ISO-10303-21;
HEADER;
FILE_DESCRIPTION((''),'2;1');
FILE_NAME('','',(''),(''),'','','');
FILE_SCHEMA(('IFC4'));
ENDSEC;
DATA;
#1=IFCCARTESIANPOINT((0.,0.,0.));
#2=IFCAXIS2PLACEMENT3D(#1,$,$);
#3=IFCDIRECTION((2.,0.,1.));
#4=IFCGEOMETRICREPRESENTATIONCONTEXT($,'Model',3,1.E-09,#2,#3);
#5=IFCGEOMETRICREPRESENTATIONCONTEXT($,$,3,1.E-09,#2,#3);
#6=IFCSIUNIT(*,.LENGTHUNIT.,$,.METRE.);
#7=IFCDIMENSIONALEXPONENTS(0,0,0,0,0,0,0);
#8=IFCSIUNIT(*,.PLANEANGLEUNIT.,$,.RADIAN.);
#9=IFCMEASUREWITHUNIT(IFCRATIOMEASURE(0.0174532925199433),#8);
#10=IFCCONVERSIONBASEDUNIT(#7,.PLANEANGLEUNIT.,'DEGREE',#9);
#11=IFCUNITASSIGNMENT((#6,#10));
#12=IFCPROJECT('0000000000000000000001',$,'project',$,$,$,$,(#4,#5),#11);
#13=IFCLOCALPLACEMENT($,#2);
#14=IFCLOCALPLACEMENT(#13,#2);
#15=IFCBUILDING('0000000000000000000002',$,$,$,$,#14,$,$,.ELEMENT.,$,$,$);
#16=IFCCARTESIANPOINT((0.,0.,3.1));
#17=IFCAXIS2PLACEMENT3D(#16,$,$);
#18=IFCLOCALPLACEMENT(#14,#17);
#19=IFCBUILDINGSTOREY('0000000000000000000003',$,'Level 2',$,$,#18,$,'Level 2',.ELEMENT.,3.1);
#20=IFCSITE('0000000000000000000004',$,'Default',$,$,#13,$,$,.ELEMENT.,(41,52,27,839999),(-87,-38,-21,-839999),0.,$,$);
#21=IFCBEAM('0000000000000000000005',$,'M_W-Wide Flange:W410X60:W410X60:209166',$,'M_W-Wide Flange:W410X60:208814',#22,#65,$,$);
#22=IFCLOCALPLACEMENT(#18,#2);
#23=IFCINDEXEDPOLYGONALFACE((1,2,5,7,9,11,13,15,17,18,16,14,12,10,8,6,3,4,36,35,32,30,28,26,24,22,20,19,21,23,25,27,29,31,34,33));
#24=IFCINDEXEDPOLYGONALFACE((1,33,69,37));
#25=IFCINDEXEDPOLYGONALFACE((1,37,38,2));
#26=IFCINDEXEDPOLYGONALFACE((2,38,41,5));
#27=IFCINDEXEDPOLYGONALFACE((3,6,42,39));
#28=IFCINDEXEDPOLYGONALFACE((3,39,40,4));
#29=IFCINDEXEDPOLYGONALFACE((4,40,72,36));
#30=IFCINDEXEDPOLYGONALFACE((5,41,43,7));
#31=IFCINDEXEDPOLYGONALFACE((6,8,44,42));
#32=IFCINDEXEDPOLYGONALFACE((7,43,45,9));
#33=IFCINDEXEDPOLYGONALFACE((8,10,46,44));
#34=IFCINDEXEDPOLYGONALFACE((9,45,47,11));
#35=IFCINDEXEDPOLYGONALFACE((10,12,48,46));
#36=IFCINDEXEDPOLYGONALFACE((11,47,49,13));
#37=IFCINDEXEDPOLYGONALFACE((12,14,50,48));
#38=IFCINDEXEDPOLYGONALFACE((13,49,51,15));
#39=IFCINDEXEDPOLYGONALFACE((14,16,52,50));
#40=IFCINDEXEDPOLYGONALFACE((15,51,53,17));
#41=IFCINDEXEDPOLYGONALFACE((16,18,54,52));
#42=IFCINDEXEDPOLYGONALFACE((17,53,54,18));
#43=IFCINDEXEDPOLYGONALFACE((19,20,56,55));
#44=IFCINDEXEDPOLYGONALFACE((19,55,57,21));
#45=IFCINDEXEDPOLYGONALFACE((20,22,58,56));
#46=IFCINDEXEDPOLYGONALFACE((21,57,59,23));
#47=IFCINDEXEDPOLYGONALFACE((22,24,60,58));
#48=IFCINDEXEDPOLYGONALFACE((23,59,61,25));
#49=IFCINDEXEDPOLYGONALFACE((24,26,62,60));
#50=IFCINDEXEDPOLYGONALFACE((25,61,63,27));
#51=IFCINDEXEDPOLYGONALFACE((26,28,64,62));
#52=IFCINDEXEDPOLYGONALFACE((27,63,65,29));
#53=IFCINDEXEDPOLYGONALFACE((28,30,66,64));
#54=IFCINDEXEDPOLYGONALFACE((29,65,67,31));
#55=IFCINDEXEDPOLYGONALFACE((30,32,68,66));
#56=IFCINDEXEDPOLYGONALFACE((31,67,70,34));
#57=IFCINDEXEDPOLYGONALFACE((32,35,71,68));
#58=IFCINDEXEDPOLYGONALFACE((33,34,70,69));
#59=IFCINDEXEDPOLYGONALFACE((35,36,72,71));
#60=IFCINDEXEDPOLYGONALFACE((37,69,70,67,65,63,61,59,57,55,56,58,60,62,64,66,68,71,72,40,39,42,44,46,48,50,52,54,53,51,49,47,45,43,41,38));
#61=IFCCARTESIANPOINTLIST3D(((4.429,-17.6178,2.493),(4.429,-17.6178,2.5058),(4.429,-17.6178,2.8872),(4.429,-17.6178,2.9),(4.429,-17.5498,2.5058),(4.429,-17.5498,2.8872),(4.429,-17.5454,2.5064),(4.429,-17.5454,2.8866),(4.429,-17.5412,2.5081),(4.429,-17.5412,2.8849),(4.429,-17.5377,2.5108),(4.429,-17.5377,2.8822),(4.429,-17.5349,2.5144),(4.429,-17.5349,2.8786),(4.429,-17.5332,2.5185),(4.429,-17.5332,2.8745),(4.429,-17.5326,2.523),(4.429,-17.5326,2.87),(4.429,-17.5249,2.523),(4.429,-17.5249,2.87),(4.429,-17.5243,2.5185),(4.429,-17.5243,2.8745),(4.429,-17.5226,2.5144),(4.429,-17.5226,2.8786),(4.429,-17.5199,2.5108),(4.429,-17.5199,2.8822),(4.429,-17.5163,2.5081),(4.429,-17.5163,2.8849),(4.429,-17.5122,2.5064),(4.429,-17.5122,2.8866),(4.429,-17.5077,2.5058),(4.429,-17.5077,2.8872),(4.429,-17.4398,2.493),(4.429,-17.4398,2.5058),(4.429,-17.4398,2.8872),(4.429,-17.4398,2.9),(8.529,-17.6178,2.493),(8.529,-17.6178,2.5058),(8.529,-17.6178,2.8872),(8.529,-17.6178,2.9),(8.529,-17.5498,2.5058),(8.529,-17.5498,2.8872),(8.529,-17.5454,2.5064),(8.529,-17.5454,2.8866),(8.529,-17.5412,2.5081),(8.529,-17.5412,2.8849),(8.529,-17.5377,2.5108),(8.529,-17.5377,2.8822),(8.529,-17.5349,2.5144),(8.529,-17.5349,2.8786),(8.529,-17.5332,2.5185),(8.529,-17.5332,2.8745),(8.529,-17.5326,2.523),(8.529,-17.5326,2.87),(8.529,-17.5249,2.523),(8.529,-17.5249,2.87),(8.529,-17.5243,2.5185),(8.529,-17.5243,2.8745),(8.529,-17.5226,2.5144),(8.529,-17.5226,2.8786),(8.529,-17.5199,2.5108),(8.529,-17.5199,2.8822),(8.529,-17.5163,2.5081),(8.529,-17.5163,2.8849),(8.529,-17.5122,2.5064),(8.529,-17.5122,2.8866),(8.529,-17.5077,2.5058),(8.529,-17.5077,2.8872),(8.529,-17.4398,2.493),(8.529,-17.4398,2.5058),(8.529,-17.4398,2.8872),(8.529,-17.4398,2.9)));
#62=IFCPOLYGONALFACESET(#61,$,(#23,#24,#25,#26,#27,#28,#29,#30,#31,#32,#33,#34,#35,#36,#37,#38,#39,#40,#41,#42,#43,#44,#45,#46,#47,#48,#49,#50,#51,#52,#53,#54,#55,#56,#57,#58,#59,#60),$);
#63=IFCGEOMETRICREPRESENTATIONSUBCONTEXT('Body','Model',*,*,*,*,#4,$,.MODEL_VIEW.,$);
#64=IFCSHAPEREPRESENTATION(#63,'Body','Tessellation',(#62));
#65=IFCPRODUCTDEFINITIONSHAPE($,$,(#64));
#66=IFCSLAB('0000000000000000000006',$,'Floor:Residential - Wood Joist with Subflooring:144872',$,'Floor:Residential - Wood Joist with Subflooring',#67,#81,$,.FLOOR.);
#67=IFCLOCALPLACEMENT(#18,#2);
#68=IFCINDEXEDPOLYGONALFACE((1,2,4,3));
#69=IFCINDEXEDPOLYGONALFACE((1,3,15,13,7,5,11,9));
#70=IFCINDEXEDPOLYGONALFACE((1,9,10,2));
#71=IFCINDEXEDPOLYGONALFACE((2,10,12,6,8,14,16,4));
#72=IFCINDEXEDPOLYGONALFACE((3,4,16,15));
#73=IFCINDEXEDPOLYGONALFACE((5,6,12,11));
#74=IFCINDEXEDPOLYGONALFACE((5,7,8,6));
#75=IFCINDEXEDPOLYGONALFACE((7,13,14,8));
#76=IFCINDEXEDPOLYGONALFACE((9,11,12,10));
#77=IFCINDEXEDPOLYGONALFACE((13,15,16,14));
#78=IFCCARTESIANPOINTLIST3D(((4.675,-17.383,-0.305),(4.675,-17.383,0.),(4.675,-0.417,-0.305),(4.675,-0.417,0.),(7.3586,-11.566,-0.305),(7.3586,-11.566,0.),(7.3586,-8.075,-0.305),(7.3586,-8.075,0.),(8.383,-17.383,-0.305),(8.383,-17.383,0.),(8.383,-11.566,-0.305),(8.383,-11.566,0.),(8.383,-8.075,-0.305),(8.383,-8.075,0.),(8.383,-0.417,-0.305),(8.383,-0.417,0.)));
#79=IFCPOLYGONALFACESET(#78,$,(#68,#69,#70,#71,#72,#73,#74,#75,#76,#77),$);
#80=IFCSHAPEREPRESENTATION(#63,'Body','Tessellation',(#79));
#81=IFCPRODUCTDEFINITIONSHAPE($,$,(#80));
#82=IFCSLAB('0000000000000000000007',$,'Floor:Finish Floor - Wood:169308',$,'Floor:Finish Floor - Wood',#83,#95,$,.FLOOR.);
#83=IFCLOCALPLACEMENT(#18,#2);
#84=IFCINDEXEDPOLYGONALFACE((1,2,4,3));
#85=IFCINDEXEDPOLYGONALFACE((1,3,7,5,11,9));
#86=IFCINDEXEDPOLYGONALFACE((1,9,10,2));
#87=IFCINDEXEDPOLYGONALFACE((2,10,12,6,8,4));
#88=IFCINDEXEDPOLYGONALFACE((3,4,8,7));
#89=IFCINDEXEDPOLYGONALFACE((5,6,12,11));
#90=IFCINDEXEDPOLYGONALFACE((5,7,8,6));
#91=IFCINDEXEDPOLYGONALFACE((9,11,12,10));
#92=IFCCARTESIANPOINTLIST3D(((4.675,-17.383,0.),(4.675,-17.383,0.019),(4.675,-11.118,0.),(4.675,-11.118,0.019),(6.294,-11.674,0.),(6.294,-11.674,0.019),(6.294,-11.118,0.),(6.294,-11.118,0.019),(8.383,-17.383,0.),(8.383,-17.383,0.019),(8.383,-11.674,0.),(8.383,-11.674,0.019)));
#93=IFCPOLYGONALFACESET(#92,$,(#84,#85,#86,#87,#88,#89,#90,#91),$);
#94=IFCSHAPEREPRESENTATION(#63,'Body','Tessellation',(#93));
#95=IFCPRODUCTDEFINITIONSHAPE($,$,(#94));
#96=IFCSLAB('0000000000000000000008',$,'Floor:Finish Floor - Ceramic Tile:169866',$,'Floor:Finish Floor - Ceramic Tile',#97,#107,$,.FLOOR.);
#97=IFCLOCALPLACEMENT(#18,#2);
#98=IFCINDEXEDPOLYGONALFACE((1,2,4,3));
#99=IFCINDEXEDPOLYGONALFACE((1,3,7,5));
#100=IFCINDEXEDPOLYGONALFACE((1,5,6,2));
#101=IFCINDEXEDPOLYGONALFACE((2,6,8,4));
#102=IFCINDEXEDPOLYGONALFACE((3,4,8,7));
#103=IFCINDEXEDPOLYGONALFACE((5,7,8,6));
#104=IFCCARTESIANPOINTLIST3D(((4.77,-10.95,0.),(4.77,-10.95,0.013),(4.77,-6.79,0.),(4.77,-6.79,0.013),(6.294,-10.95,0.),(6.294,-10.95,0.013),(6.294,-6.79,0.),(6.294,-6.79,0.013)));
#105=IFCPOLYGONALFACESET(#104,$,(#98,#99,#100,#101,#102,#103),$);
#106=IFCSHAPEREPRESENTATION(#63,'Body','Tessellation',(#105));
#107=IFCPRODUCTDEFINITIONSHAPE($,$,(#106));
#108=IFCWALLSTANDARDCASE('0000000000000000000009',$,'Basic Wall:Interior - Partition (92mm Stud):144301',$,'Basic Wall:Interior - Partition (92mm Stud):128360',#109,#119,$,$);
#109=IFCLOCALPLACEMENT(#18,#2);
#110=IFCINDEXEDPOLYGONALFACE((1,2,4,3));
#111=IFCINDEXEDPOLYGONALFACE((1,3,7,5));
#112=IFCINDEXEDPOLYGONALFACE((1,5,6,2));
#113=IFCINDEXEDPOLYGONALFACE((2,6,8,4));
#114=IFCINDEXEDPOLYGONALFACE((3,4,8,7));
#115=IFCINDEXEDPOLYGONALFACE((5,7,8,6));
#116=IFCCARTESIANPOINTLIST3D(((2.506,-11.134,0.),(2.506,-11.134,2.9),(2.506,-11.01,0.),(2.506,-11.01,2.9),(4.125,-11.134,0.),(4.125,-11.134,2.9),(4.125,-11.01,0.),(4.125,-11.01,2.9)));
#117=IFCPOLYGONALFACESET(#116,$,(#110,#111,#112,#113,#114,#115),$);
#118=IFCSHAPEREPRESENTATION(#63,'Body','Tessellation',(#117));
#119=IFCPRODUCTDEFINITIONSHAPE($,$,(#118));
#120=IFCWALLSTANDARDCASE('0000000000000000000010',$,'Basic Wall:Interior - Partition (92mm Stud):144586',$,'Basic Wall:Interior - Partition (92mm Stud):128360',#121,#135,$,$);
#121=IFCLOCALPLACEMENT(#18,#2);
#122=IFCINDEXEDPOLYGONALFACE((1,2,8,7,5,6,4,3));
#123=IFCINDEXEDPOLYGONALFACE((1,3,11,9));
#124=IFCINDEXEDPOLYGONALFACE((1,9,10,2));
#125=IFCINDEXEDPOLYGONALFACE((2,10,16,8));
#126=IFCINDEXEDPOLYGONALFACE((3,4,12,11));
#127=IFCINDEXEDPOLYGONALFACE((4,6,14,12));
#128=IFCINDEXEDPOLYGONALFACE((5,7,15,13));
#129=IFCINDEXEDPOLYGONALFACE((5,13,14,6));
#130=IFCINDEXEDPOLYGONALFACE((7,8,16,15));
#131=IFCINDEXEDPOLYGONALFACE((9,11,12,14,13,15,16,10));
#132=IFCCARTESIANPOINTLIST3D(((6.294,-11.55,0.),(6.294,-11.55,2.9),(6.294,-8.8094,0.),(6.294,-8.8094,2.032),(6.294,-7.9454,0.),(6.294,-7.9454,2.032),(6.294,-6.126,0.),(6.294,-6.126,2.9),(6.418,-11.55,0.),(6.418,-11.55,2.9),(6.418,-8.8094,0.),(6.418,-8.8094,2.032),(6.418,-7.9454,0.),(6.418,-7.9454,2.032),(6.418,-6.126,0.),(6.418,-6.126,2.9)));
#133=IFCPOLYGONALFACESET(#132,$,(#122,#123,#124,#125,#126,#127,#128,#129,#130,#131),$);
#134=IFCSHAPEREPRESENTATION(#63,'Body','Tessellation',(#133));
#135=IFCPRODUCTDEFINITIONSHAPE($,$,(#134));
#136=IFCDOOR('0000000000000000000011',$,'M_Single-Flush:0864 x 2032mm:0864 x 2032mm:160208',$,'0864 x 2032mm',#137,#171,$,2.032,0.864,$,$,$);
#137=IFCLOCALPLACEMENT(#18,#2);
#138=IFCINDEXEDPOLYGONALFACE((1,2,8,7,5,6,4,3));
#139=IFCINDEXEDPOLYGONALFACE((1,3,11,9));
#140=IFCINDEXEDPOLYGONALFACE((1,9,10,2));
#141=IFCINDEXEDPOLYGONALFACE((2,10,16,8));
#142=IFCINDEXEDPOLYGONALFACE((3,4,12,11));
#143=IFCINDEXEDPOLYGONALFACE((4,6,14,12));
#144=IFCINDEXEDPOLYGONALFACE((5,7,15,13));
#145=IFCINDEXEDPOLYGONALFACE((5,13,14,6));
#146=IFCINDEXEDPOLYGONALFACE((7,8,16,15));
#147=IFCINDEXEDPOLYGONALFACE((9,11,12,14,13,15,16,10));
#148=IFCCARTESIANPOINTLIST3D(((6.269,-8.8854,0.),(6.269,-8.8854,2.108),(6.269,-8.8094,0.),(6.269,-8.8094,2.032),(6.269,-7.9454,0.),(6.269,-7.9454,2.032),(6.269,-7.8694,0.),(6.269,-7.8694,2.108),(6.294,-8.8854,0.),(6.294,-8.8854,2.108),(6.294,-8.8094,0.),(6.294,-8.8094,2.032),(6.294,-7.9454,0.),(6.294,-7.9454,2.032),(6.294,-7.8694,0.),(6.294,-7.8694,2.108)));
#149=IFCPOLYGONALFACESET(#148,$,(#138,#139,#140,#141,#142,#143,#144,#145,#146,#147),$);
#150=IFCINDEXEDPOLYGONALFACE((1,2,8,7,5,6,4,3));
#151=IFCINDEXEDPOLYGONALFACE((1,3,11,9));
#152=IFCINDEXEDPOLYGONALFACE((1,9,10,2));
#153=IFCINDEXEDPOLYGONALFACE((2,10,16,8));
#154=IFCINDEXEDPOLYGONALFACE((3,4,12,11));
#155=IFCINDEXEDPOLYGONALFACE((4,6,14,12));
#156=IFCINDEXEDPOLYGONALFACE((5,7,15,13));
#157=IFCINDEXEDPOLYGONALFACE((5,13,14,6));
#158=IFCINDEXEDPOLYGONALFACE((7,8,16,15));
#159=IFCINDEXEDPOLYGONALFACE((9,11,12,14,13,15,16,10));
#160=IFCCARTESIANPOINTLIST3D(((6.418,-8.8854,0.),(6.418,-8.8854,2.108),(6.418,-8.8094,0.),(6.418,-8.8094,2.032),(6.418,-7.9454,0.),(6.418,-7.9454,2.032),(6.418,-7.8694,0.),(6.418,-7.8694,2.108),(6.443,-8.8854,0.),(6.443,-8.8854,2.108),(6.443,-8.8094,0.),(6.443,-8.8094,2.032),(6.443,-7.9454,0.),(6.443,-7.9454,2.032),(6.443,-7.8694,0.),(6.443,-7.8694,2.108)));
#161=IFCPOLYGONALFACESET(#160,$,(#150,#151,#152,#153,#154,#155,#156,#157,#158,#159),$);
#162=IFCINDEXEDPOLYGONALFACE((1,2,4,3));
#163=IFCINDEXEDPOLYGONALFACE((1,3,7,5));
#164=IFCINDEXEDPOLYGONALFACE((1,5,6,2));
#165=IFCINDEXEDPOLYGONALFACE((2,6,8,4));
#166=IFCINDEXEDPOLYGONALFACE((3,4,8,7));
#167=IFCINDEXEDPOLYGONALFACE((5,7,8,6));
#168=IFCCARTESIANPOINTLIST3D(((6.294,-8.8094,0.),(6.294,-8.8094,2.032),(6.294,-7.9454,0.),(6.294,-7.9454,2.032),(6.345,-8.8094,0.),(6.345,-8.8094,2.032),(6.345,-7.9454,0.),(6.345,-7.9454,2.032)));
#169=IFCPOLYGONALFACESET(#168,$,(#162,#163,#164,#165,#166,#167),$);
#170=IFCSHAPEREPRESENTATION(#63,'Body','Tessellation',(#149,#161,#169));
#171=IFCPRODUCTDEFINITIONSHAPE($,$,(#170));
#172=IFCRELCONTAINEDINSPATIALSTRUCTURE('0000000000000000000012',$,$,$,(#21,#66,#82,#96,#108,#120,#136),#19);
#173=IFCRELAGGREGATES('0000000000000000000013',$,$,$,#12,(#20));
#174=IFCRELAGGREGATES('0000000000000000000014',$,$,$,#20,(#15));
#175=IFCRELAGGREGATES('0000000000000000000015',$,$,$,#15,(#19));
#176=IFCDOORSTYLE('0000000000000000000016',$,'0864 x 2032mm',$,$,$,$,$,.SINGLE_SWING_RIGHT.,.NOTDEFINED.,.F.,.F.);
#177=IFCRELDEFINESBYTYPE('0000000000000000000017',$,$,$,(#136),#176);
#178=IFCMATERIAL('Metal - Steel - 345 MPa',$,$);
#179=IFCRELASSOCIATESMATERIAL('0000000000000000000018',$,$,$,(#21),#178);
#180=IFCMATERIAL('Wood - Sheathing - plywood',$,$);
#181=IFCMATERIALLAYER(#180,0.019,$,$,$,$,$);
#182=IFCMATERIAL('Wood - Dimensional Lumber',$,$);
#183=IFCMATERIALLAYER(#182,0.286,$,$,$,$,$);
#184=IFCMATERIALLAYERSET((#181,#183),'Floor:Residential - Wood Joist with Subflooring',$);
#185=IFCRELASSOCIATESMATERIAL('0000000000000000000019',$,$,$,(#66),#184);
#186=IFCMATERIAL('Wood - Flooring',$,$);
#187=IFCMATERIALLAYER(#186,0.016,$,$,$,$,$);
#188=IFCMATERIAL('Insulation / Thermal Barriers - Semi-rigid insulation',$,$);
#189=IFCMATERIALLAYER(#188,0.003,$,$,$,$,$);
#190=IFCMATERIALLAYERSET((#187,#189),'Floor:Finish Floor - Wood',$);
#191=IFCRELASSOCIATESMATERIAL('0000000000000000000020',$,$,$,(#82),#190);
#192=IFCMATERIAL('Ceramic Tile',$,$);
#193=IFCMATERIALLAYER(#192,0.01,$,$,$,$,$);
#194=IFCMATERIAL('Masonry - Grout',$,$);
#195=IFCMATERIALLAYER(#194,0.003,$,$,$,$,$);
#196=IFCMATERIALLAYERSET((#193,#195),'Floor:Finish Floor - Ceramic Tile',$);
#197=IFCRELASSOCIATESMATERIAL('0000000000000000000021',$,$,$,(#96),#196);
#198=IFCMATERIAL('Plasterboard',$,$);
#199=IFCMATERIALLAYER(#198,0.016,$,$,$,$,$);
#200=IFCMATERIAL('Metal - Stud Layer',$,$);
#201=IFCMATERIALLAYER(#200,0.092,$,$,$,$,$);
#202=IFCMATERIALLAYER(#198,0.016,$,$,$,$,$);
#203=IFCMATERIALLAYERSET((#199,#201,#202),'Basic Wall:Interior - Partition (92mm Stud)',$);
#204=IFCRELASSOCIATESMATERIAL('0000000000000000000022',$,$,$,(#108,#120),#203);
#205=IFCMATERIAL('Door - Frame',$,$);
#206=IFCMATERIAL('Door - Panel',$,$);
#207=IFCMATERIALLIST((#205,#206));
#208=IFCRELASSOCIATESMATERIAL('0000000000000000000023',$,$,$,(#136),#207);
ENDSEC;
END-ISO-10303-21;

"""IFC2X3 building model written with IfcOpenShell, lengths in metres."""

from ifc_helpers import new_model, entity, si_unit, converted_unit, direction, frame, frame_2d, origin, origin_2d_with_axis, place, context, subcontext, project, spatial, polyline, rectangle, i_section, outline, extrude, source, transform, mapped, material, material_list, layer, layer_set, layer_usage, type_object, type_shapes, element, fill, save


model = new_model("IFC2X3")

# Units and contexts
model_context = context("Model", 3, precision=1e-09, world=origin(), true_north=direction((2.0, 0.0, 1.0)))
context_of_model = context(None, 3, precision=1e-09, world=origin(), true_north=direction((2.0, 0.0, 1.0)))
body_context = subcontext(model_context, "Body", "Model", "MODEL_VIEW")
ifc_project = project(units=[si_unit("LENGTHUNIT", "METRE"), converted_unit("PLANEANGLEUNIT", "DEGREE", entity("IfcRatioMeasure", 0.0174532925199433), si_unit("PLANEANGLEUNIT", "RADIAN"), dimensions=[0, 0, 0, 0, 0, 0, 0])], contexts=[model_context, context_of_model])

# Site, building, storey
site_placement = place(None, origin())
site = spatial("IfcSite", under=ifc_project, at=site_placement, Name="Default", CompositionType="ELEMENT", RefLatitude=(41, 52, 27, 839999), RefLongitude=(-87, -38, -21, -839999), RefElevation=0.0)
building_placement = place(site_placement, origin())
building = spatial("IfcBuilding", under=site, at=building_placement, CompositionType="ELEMENT")
storey_placement = place(building_placement, frame((0.0, 0.0, 3.1)))
storey = spatial("IfcBuildingStorey", under=building, at=storey_placement, Name="Level 2", LongName="Level 2", CompositionType="ELEMENT", Elevation=3.1)

# Beam
ifc_material_1 = material(Name="Metal - Steel - 345 MPa")
beam_placement = place(storey_placement, frame((4.429, -17.5288, 2.9)))
element("IfcBeam", 1, at=beam_placement, inside=storey, material=ifc_material_1, Name="M_W-Wide Flange:W410X60:W410X60:209166", ObjectType="M_W-Wide Flange:W410X60:208814", context=body_context, shape_type="SweptSolid", body=[
    extrude(i_section(OverallWidth=0.178, OverallDepth=0.407, WebThickness=0.0077, FlangeThickness=0.0128, FilletRadius=0.0172, at=frame_2d((0.0, 0.0), x_axis=(1.0, 0.0))), frame((0.0, 0.0, -0.2035), z_axis=(-1.0, 0.0, 0.0), x_axis=(0.0, -1.0, 0.0)), (0.0, 0.0, -1.0), 4.1),
])

# Slabs
ifc_material_2 = material(Name="Wood - Sheathing - plywood")
ifc_layer_1 = layer(ifc_material_2, 0.019)
ifc_material_3 = material(Name="Wood - Dimensional Lumber")
ifc_layer_2 = layer(ifc_material_3, 0.286)
ifc_layer_set_1 = layer_set([ifc_layer_1, ifc_layer_2], Name="Floor:Residential - Wood Joist with Subflooring")
ifc_layer_usage_1 = layer_usage(ifc_layer_set_1, "AXIS3", "POSITIVE", 0.0)
slab_1_placement = place(storey_placement, frame((4.675, -17.383, -0.305)))
element("IfcSlab", 2, at=slab_1_placement, inside=storey, material=ifc_layer_usage_1, Name="Floor:Residential - Wood Joist with Subflooring:144872", ObjectType="Floor:Residential - Wood Joist with Subflooring", PredefinedType="FLOOR", context=body_context, shape_type="SweptSolid", body=[
    extrude(outline(polyline([(-1.854, 8.483), (-1.854, 0.825), (-0.8296, 0.825), (-0.8296, -2.666), (-1.854, -2.666), (-1.854, -8.483), (1.854, -8.483), (1.854, 8.483), (-1.854, 8.483)])), frame((1.854, 8.483, 0.305), z_axis=(0.0, 0.0, -1.0), x_axis=(-1.0, 0.0, 0.0)), (0.0, 0.0, 1.0), 0.305),
])
ifc_material_4 = material(Name="Wood - Flooring")
ifc_layer_3 = layer(ifc_material_4, 0.016)
ifc_material_5 = material(Name="Insulation / Thermal Barriers - Semi-rigid insulation")
ifc_layer_4 = layer(ifc_material_5, 0.003)
ifc_layer_set_2 = layer_set([ifc_layer_3, ifc_layer_4], Name="Floor:Finish Floor - Wood")
ifc_layer_usage_2 = layer_usage(ifc_layer_set_2, "AXIS3", "POSITIVE", 0.0)
slab_2_placement = place(storey_placement, frame((4.675, -17.383, 0.0)))
element("IfcSlab", 3, at=slab_2_placement, inside=storey, material=ifc_layer_usage_2, Name="Floor:Finish Floor - Wood:169308", ObjectType="Floor:Finish Floor - Wood", PredefinedType="FLOOR", context=body_context, shape_type="SweptSolid", body=[
    extrude(outline(polyline([(-1.854, 2.5765), (-1.854, -3.1325), (1.854, -3.1325), (1.854, 3.1325), (0.235, 3.1325), (0.235, 2.5765), (-1.854, 2.5765)])), frame((1.854, 3.1325, 0.019), z_axis=(0.0, 0.0, -1.0), x_axis=(-1.0, 0.0, 0.0)), (0.0, 0.0, 1.0), 0.019),
])
ifc_material_6 = material(Name="Ceramic Tile")
ifc_layer_5 = layer(ifc_material_6, 0.01)
ifc_material_7 = material(Name="Masonry - Grout")
ifc_layer_6 = layer(ifc_material_7, 0.003)
ifc_layer_set_3 = layer_set([ifc_layer_5, ifc_layer_6], Name="Floor:Finish Floor - Ceramic Tile")
ifc_layer_usage_3 = layer_usage(ifc_layer_set_3, "AXIS3", "POSITIVE", 0.0)
slab_3_placement = place(storey_placement, frame((4.77, -10.95, 0.0)))
element("IfcSlab", 4, at=slab_3_placement, inside=storey, material=ifc_layer_usage_3, Name="Floor:Finish Floor - Ceramic Tile:169866", ObjectType="Floor:Finish Floor - Ceramic Tile", PredefinedType="FLOOR", context=body_context, shape_type="SweptSolid", body=[
    extrude(rectangle(XDim=4.16, YDim=1.524, at=frame_2d((0.0, 0.0), x_axis=(0.0, -1.0))), frame((0.762, 2.08, 0.013), z_axis=(0.0, 0.0, -1.0), x_axis=(-1.0, 0.0, 0.0)), (0.0, 0.0, 1.0), 0.013),
])

# Shared definitions
ifc_material_8 = material(Name="Metal - Stud Layer")
ifc_material_9 = material(Name="Plasterboard")

# Wall
ifc_layer_7 = layer(ifc_material_9, 0.016)
ifc_layer_8 = layer(ifc_material_8, 0.092)
ifc_layer_9 = layer(ifc_material_9, 0.016)
ifc_layer_set_4 = layer_set([ifc_layer_7, ifc_layer_8, ifc_layer_9], Name="Basic Wall:Interior - Partition (92mm Stud)")
ifc_layer_usage_4 = layer_usage(ifc_layer_set_4, "AXIS2", "NEGATIVE", 0.062)
wall_1_placement = place(storey_placement, frame((4.125, -11.072, 0.0), z_axis=(0.0, 0.0, 1.0), x_axis=(-1.0, 0.0, 0.0)))
element("IfcWallStandardCase", 5, at=wall_1_placement, inside=storey, material=ifc_layer_usage_4, Name="Basic Wall:Interior - Partition (92mm Stud):144301", ObjectType="Basic Wall:Interior - Partition (92mm Stud):128360", context=body_context, shape_type="SweptSolid", body=[
    extrude(rectangle(XDim=1.619, YDim=0.124, at=frame_2d((0.8095, 0.0), x_axis=(-1.0, 0.0))), origin(), (0.0, 0.0, 1.0), 2.9),
])

# Wall, opening, door
ifc_layer_usage_5 = layer_usage(ifc_layer_set_4, "AXIS2", "NEGATIVE", 0.062)
wall_2_placement = place(storey_placement, frame((6.356, -11.55, 0.0), z_axis=(0.0, 0.0, 1.0), x_axis=(0.0, 1.0, 0.0)))
wall_2 = element("IfcWallStandardCase", 6, at=wall_2_placement, inside=storey, material=ifc_layer_usage_5, Name="Basic Wall:Interior - Partition (92mm Stud):144586", ObjectType="Basic Wall:Interior - Partition (92mm Stud):128360", context=body_context, shape_type="SweptSolid", body=[
    extrude(rectangle(XDim=5.424, YDim=0.124, at=frame_2d((2.712, 0.0), x_axis=(-1.0, 0.0))), origin(), (0.0, 0.0, 1.0), 2.9),
])
opening_1_placement = place(wall_2_placement, frame((2.7406, -0.062, 0.0)))
opening_1 = element("IfcOpeningElement", 7, at=opening_1_placement, cuts=wall_2, ObjectType="Opening", context=body_context, shape_type="SweptSolid", body=[
    extrude(rectangle(XDim=0.864, YDim=2.032, at=frame_2d((1.016, 0.432), x_axis=(0.0, 1.0))), frame((0.0, 0.0, 0.0), z_axis=(0.0, 1.0, 0.0), x_axis=(0.0, 0.0, 1.0)), (0.0, 0.0, 1.0), 0.124),
])
ifc_material_10 = material(Name="Door - Frame")
ifc_material_11 = material(Name="Door - Panel")
ifc_material_list_1 = material_list([ifc_material_10, ifc_material_11])
door_style = type_object("IfcDoorStyle", Name="0864 x 2032mm", ConstructionType="NOTDEFINED", OperationType="SINGLE_SWING_RIGHT", ParameterTakesPrecedence=False, Sizeable=False)
shared_shape_1 = source(origin(), body_context, "Body", "SweptSolid", [
    extrude(outline(polyline([(-0.508, -1.073), (0.508, -1.073), (0.508, 1.035), (0.432, 1.035), (0.432, -0.997), (-0.432, -0.997), (-0.432, 1.035), (-0.508, 1.035), (-0.508, -1.073)])), frame((0.432, 0.124, 1.035), z_axis=(0.0, 1.0, 0.0), x_axis=(1.0, 0.0, 0.0)), (0.0, 0.0, 1.0), 0.025),
    extrude(outline(polyline([(-1.073, -0.508), (1.035, -0.508), (1.035, -0.432), (-0.997, -0.432), (-0.997, 0.432), (1.035, 0.432), (1.035, 0.508), (-1.073, 0.508), (-1.073, -0.508)])), frame((0.432, -0.025, 1.035), z_axis=(0.0, 1.0, 0.0), x_axis=(0.0, 0.0, -1.0)), (0.0, 0.0, 1.0), 0.025),
    extrude(rectangle(XDim=0.051, YDim=0.864, at=origin_2d_with_axis()), frame((0.432, 0.0985, 0.0), z_axis=(0.0, 0.0, 1.0), x_axis=(0.0, 1.0, 0.0)), (0.0, 0.0, 1.0), 2.032),
])
type_shapes(door_style, [shared_shape_1])
door_placement = place(opening_1_placement, origin())
door = element("IfcDoor", 8, at=door_placement, inside=storey, type_object=door_style, material=ifc_material_list_1, Name="M_Single-Flush:0864 x 2032mm:0864 x 2032mm:160208", ObjectType="0864 x 2032mm", OverallHeight=2.032, OverallWidth=0.864, context=body_context, shape_type="MappedRepresentation", body=[
    mapped(shared_shape_1, transform((0.0, 0.0, 0.0), scale=1.0)),
])
fill(opening_1, door)

save(model, "model.ifc")
